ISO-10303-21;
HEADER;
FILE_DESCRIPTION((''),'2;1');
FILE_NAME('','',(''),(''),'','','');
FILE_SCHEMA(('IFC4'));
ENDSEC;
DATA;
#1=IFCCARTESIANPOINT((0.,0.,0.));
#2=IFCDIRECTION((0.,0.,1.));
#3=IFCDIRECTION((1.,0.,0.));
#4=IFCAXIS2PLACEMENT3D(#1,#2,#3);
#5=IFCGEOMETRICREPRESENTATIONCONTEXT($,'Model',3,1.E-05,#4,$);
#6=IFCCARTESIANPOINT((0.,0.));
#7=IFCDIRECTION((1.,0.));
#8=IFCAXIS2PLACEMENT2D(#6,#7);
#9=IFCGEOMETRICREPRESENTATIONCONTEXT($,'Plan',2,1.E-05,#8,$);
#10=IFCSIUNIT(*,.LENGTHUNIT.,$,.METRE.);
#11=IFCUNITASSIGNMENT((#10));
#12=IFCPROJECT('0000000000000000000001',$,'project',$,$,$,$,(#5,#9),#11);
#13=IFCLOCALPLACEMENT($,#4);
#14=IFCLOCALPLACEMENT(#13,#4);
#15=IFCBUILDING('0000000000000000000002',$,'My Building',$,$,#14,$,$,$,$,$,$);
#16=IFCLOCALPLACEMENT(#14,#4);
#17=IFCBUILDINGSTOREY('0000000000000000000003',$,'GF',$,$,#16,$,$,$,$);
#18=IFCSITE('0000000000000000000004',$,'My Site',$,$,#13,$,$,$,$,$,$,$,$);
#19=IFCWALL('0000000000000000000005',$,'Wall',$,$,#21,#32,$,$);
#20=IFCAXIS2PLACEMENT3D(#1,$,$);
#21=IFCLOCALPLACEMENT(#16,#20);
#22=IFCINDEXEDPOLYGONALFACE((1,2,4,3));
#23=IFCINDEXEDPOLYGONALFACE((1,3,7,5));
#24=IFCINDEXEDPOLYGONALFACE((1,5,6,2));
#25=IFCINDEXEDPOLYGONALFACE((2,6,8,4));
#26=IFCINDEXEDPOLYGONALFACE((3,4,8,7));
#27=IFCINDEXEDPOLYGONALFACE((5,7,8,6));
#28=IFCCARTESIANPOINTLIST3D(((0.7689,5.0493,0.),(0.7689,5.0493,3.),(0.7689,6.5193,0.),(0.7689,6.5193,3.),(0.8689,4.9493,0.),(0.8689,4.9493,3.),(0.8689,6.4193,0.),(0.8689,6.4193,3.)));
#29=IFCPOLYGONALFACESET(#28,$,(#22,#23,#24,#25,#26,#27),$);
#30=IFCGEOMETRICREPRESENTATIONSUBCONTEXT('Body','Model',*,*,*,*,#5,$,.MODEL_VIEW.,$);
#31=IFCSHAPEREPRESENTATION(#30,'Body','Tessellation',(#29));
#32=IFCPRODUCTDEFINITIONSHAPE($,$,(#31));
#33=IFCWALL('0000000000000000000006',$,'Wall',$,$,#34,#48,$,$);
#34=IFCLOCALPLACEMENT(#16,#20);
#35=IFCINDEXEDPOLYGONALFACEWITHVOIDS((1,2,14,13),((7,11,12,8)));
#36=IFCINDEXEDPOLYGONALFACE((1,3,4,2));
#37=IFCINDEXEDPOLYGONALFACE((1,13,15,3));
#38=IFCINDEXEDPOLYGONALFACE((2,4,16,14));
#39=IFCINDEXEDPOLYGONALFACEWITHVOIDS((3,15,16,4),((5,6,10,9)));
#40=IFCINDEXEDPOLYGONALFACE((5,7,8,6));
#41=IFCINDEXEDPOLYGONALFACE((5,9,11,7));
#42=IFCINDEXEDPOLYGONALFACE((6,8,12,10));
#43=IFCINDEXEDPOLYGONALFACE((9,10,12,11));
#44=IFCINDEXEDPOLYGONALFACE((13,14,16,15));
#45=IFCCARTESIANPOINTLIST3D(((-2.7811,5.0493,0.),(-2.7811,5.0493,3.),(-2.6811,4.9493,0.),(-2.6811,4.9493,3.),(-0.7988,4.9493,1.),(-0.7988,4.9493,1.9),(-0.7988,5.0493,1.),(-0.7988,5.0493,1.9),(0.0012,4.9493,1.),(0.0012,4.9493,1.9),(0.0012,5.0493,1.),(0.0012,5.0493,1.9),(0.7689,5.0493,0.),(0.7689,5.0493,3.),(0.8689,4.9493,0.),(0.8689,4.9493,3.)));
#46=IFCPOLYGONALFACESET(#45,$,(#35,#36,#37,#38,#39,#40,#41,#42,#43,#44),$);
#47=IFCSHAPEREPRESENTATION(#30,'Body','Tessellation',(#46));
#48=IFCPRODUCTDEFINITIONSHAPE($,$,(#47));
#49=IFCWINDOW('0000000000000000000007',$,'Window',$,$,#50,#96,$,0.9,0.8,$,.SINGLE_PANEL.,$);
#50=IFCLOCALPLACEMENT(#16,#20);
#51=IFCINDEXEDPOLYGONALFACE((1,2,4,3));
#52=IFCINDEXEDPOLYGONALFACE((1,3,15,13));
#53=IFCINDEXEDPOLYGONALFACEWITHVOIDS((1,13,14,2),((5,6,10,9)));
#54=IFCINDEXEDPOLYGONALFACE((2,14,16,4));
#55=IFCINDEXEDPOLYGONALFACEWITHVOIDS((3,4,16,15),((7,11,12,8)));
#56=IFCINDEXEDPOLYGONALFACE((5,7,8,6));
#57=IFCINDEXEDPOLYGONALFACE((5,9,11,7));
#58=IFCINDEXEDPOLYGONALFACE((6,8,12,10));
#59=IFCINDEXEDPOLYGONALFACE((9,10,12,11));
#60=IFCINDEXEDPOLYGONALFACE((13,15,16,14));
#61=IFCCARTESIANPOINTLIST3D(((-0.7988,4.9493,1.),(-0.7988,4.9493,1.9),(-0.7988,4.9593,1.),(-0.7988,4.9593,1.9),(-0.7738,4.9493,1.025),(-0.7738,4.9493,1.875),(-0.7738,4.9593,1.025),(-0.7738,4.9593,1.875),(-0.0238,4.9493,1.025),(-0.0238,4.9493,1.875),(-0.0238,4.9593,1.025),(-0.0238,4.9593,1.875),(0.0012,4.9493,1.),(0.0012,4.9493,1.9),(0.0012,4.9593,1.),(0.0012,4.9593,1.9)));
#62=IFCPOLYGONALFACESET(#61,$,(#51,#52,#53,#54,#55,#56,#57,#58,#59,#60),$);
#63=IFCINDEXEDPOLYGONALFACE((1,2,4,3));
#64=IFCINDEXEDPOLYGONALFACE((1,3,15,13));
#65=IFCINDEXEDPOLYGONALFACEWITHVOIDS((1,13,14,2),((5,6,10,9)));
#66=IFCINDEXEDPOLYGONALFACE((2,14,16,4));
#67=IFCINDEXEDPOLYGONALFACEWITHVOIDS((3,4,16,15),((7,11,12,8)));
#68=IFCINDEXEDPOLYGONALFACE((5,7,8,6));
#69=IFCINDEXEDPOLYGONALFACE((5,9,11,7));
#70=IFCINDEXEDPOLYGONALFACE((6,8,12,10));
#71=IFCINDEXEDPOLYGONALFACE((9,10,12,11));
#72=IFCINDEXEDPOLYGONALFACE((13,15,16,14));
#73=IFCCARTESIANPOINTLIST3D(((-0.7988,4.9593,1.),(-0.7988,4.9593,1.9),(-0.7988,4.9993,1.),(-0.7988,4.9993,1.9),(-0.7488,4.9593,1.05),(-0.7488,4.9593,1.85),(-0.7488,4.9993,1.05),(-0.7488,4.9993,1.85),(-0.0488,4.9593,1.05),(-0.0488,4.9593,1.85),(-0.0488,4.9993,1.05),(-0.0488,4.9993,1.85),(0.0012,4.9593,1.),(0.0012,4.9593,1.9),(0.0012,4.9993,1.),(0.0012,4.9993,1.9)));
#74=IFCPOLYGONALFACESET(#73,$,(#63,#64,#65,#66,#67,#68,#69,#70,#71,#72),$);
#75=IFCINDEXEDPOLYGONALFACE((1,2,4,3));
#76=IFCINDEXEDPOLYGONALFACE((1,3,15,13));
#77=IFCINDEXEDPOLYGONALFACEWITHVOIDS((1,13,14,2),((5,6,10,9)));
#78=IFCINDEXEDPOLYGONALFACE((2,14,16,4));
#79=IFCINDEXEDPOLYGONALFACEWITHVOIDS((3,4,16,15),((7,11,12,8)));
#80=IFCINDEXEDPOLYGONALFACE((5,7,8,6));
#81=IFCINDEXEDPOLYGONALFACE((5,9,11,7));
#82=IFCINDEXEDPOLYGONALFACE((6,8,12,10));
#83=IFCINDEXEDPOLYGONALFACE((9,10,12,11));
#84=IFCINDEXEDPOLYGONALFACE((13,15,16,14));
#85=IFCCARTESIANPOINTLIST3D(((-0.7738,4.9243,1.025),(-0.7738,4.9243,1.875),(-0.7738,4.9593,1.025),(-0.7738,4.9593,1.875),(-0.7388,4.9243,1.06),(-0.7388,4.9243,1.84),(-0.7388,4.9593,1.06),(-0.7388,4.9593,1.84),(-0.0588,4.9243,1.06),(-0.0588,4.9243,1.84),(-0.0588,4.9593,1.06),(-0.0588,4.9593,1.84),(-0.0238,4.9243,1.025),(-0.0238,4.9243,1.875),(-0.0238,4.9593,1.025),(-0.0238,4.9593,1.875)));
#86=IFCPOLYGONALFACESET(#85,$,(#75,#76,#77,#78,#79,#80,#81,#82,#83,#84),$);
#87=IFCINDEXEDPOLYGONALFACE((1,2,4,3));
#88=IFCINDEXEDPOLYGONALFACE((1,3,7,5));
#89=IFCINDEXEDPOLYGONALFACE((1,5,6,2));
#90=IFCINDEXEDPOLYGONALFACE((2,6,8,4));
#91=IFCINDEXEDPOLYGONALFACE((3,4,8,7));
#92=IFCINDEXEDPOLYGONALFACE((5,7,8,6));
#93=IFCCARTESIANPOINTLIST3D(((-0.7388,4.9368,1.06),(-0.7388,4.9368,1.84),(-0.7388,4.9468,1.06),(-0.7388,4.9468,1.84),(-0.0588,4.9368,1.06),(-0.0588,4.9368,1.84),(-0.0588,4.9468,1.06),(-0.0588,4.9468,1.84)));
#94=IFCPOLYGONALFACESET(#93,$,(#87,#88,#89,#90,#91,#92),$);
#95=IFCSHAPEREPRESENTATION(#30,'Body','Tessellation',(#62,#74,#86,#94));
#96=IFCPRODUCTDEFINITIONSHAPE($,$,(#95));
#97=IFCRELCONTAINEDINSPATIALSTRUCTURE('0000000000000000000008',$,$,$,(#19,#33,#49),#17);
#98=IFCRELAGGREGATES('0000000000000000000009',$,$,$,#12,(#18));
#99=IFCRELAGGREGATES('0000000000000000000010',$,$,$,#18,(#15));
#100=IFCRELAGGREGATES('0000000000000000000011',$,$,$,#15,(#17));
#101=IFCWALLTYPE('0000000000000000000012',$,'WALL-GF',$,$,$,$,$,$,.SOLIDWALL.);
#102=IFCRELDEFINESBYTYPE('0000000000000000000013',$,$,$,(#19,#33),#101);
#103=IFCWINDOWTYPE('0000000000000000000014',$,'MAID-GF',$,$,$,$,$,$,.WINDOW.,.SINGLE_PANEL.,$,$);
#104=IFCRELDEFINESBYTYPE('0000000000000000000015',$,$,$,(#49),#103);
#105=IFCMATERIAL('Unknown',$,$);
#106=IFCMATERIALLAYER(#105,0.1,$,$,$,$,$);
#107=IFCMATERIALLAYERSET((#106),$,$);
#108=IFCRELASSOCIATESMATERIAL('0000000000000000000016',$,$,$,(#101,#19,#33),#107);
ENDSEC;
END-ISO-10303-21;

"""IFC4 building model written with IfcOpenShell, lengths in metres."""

from ifc_helpers import new_model, entity, si_unit, frame, origin_with_axes, origin_2d_with_axis, place, context, subcontext, project, spatial, line, indexed_curve, outline, extrude, shape, source, transform, mapped, material, layer, layer_set, layer_usage, type_object, type_shapes, element, fill, save


model = new_model("IFC4")

# Units and contexts
model_context = context("Model", 3, precision=1e-05, world=origin_with_axes())
plan_context = context("Plan", 2, precision=1e-05, world=origin_2d_with_axis())
body_context_1 = subcontext(model_context, "Body", "Model", "MODEL_VIEW")
body_context_2 = subcontext(plan_context, "Body", "Plan", "PLAN_VIEW")
ifc_project = project(units=[si_unit("LENGTHUNIT", "METRE")], contexts=[model_context, plan_context])

# Site, building, storey
site_placement = place(None, origin_with_axes())
site = spatial("IfcSite", under=ifc_project, at=site_placement, Name="My Site")
building_placement = place(site_placement, origin_with_axes())
building = spatial("IfcBuilding", under=site, at=building_placement, Name="My Building")
storey_placement = place(building_placement, origin_with_axes())
storey = spatial("IfcBuildingStorey", under=building, at=storey_placement, Name="GF")

# Shared definitions
ifc_material_1 = material(Name="Unknown")

# Wall
ifc_layer_1 = layer(ifc_material_1, 0.1)
ifc_layer_set_1 = layer_set([ifc_layer_1])
wall_type = type_object("IfcWallType", Name="WALL-GF", PredefinedType="SOLIDWALL", material=ifc_layer_set_1)
ifc_layer_usage_1 = layer_usage(ifc_layer_set_1, "AXIS2", "POSITIVE", 0.0)
wall_1_placement = place(storey_placement, frame((0.7689, 6.5193, 0.0), z_axis=(0.0, 0.0, 1.0), x_axis=(0.0, -1.0, 0.0)))
element("IfcWall", 1, at=wall_1_placement, inside=storey, type_object=wall_type, material=ifc_layer_usage_1, Name="Wall", context=body_context_1, shape_type="SweptSolid", body=[
    extrude(outline(indexed_curve([(0.0, 0.0), (0.1, 0.1), (1.57, 0.1), (1.47, 0.0)], segments=[line(1, 2, 3, 4, 1)])), origin_with_axes(), (0.0, 0.0, 1.0), 3.0),
])

# Wall, opening, window
ifc_layer_usage_2 = layer_usage(ifc_layer_set_1, "AXIS2", "POSITIVE", 0.0)
wall_2_placement = place(storey_placement, frame((0.7689, 5.0493, 0.0), z_axis=(0.0, 0.0, 1.0), x_axis=(-1.0, 0.0, 0.0)))
wall_2 = element("IfcWall", 2, at=wall_2_placement, inside=storey, type_object=wall_type, material=ifc_layer_usage_2, Name="Wall", context=body_context_1, shape_type="SweptSolid", body=[
    extrude(outline(indexed_curve([(0.0, 0.0), (-0.1, 0.1), (3.45, 0.1), (3.55, 0.0)], segments=[line(1, 2, 3, 4, 1)])), origin_with_axes(), (0.0, 0.0, 1.0), 3.0),
])
shared_shape_1 = source(origin_with_axes(), body_context_1, "Body", "SweptSolid", [
    extrude(outline(indexed_curve([(0.0, 0.0), (0.8, 0.0), (0.8, 0.9), (0.0, 0.9)], segments=[line(1, 2, 3, 4, 1)])), frame((0.0, -0.6, 0.0), z_axis=(0.0, -1.0, 0.0), x_axis=(1.0, 0.0, 0.0)), (0.0, 0.0, -1.0), 1.2),
])
opening_1_placement = place(wall_2_placement, frame((0.7678, 0.0, 1.0), z_axis=(0.0, 0.0, 1.0), x_axis=(1.0, 0.0, 0.0)))
opening_1 = element("IfcOpeningElement", 3, at=opening_1_placement, cuts=wall_2, PredefinedType="OPENING", context=body_context_1, shape_type="MappedRepresentation", body=[
    mapped(shared_shape_1, transform((0.0, 0.0, 0.0), x_axis=(1.0, 0.0, 0.0), y_axis=(0.0, 1.0, 0.0), z_axis=(0.0, 0.0, 1.0), scale=1.0)),
])
window_type_1 = type_object("IfcWindowType", Name="MAID-GF", PartitioningType="SINGLE_PANEL", PredefinedType="WINDOW")
shared_shape_2 = source(origin_with_axes(), body_context_1, "Body", "SweptSolid", [
    extrude(outline(indexed_curve([(0.0, 0.0), (0.8, 0.0), (0.8, 0.9), (0.0, 0.9)], segments=[line(1, 2, 3, 4, 1)]), holes=[indexed_curve([(0.025, 0.025), (0.775, 0.025), (0.775, 0.875), (0.025, 0.875)], segments=[line(1, 2, 3, 4, 1)])]), frame((0.0, 0.09, 0.0), z_axis=(0.0, -1.0, 0.0), x_axis=(1.0, 0.0, 0.0)), (0.0, 0.0, -1.0), 0.01),
    extrude(outline(indexed_curve([(0.0, 0.0), (0.8, 0.0), (0.8, 0.9), (0.0, 0.9)], segments=[line(1, 2, 3, 4, 1)]), holes=[indexed_curve([(0.05, 0.05), (0.75, 0.05), (0.75, 0.85), (0.05, 0.85)], segments=[line(1, 2, 3, 4, 1)])]), frame((0.0, 0.05, 0.0), z_axis=(0.0, -1.0, 0.0), x_axis=(1.0, 0.0, 0.0)), (0.0, 0.0, -1.0), 0.04),
    extrude(outline(indexed_curve([(0.0, 0.0), (0.75, 0.0), (0.75, 0.85), (0.0, 0.85)], segments=[line(1, 2, 3, 4, 1)]), holes=[indexed_curve([(0.035, 0.035), (0.715, 0.035), (0.715, 0.815), (0.035, 0.815)], segments=[line(1, 2, 3, 4, 1)])]), frame((0.025, 0.09, 0.025), z_axis=(0.0, -1.0, 0.0), x_axis=(1.0, 0.0, 0.0)), (0.0, 0.0, -1.0), 0.035),
    extrude(outline(indexed_curve([(0.035, 0.035), (0.715, 0.035), (0.715, 0.815), (0.035, 0.815)], segments=[line(1, 2, 3, 4, 1)])), frame((0.025, 0.1025, 0.025), z_axis=(0.0, -1.0, 0.0), x_axis=(1.0, 0.0, 0.0)), (0.0, 0.0, -1.0), 0.01),
])
shared_shape_3 = source(origin_with_axes(), body_context_2, "Body", "Curve2D", [
    entity("IfcIndexedPolyCurve", entity("IfcCartesianPointList2D", [[0.05, 0.05], [0.75, 0.05]])),
    entity("IfcIndexedPolyCurve", entity("IfcCartesianPointList2D", [[0.0, 0.1], [0.025, 0.1], [0.025, 0.09], [0.05, 0.09], [0.05, 0.05], [0.0, 0.05]]), [entity("IfcLineIndex", [1, 2, 3, 4, 5, 6, 1])]),
    entity("IfcIndexedPolyCurve", entity("IfcCartesianPointList2D", [[0.8, 0.1], [0.775, 0.1], [0.775, 0.09], [0.75, 0.09], [0.75, 0.05], [0.8, 0.05]]), [entity("IfcLineIndex", [1, 2, 3, 4, 5, 6, 1])]),
    entity("IfcIndexedPolyCurve", entity("IfcCartesianPointList2D", [[0.025, 0.09], [0.06, 0.09], [0.06, 0.125], [0.025, 0.125]]), [entity("IfcLineIndex", [1, 2, 3, 4, 1])]),
    entity("IfcIndexedPolyCurve", entity("IfcCartesianPointList2D", [[0.775, 0.09], [0.74, 0.09], [0.74, 0.125], [0.775, 0.125]]), [entity("IfcLineIndex", [1, 2, 3, 4, 1])]),
    entity("IfcIndexedPolyCurve", entity("IfcCartesianPointList2D", [[0.06, 0.09], [0.74, 0.09]])),
    entity("IfcIndexedPolyCurve", entity("IfcCartesianPointList2D", [[0.06, 0.125], [0.74, 0.125]])),
    entity("IfcIndexedPolyCurve", entity("IfcCartesianPointList2D", [[0.06, 0.1075], [0.74, 0.1075]])),
])
type_shapes(window_type_1, [shared_shape_2, shared_shape_3])
window_1_placement = place(opening_1_placement, frame((0.0, 0.0, 0.0), z_axis=(0.0, 0.0, 1.0), x_axis=(1.0, 0.0, 0.0)))
window_1 = element("IfcWindow", 4, at=window_1_placement, inside=storey, type_object=window_type_1, Name="Window", OverallHeight=0.9, OverallWidth=0.8, PartitioningType="SINGLE_PANEL", shapes=[
    shape(body_context_1, "Body", "MappedRepresentation", [mapped(shared_shape_2, transform((0.0, 0.0, 0.0), x_axis=(1.0, 0.0, 0.0), y_axis=(0.0, 1.0, 0.0), z_axis=(0.0, 0.0, 1.0), scale=1.0))]),
    shape(body_context_2, "Body", "MappedRepresentation", [mapped(shared_shape_3, transform((0.0, 0.0, 0.0), x_axis=(1.0, 0.0, 0.0), y_axis=(0.0, 1.0, 0.0), z_axis=(0.0, 0.0, 1.0), scale=1.0))]),
])
fill(opening_1, window_1)

save(model, "model.ifc")
